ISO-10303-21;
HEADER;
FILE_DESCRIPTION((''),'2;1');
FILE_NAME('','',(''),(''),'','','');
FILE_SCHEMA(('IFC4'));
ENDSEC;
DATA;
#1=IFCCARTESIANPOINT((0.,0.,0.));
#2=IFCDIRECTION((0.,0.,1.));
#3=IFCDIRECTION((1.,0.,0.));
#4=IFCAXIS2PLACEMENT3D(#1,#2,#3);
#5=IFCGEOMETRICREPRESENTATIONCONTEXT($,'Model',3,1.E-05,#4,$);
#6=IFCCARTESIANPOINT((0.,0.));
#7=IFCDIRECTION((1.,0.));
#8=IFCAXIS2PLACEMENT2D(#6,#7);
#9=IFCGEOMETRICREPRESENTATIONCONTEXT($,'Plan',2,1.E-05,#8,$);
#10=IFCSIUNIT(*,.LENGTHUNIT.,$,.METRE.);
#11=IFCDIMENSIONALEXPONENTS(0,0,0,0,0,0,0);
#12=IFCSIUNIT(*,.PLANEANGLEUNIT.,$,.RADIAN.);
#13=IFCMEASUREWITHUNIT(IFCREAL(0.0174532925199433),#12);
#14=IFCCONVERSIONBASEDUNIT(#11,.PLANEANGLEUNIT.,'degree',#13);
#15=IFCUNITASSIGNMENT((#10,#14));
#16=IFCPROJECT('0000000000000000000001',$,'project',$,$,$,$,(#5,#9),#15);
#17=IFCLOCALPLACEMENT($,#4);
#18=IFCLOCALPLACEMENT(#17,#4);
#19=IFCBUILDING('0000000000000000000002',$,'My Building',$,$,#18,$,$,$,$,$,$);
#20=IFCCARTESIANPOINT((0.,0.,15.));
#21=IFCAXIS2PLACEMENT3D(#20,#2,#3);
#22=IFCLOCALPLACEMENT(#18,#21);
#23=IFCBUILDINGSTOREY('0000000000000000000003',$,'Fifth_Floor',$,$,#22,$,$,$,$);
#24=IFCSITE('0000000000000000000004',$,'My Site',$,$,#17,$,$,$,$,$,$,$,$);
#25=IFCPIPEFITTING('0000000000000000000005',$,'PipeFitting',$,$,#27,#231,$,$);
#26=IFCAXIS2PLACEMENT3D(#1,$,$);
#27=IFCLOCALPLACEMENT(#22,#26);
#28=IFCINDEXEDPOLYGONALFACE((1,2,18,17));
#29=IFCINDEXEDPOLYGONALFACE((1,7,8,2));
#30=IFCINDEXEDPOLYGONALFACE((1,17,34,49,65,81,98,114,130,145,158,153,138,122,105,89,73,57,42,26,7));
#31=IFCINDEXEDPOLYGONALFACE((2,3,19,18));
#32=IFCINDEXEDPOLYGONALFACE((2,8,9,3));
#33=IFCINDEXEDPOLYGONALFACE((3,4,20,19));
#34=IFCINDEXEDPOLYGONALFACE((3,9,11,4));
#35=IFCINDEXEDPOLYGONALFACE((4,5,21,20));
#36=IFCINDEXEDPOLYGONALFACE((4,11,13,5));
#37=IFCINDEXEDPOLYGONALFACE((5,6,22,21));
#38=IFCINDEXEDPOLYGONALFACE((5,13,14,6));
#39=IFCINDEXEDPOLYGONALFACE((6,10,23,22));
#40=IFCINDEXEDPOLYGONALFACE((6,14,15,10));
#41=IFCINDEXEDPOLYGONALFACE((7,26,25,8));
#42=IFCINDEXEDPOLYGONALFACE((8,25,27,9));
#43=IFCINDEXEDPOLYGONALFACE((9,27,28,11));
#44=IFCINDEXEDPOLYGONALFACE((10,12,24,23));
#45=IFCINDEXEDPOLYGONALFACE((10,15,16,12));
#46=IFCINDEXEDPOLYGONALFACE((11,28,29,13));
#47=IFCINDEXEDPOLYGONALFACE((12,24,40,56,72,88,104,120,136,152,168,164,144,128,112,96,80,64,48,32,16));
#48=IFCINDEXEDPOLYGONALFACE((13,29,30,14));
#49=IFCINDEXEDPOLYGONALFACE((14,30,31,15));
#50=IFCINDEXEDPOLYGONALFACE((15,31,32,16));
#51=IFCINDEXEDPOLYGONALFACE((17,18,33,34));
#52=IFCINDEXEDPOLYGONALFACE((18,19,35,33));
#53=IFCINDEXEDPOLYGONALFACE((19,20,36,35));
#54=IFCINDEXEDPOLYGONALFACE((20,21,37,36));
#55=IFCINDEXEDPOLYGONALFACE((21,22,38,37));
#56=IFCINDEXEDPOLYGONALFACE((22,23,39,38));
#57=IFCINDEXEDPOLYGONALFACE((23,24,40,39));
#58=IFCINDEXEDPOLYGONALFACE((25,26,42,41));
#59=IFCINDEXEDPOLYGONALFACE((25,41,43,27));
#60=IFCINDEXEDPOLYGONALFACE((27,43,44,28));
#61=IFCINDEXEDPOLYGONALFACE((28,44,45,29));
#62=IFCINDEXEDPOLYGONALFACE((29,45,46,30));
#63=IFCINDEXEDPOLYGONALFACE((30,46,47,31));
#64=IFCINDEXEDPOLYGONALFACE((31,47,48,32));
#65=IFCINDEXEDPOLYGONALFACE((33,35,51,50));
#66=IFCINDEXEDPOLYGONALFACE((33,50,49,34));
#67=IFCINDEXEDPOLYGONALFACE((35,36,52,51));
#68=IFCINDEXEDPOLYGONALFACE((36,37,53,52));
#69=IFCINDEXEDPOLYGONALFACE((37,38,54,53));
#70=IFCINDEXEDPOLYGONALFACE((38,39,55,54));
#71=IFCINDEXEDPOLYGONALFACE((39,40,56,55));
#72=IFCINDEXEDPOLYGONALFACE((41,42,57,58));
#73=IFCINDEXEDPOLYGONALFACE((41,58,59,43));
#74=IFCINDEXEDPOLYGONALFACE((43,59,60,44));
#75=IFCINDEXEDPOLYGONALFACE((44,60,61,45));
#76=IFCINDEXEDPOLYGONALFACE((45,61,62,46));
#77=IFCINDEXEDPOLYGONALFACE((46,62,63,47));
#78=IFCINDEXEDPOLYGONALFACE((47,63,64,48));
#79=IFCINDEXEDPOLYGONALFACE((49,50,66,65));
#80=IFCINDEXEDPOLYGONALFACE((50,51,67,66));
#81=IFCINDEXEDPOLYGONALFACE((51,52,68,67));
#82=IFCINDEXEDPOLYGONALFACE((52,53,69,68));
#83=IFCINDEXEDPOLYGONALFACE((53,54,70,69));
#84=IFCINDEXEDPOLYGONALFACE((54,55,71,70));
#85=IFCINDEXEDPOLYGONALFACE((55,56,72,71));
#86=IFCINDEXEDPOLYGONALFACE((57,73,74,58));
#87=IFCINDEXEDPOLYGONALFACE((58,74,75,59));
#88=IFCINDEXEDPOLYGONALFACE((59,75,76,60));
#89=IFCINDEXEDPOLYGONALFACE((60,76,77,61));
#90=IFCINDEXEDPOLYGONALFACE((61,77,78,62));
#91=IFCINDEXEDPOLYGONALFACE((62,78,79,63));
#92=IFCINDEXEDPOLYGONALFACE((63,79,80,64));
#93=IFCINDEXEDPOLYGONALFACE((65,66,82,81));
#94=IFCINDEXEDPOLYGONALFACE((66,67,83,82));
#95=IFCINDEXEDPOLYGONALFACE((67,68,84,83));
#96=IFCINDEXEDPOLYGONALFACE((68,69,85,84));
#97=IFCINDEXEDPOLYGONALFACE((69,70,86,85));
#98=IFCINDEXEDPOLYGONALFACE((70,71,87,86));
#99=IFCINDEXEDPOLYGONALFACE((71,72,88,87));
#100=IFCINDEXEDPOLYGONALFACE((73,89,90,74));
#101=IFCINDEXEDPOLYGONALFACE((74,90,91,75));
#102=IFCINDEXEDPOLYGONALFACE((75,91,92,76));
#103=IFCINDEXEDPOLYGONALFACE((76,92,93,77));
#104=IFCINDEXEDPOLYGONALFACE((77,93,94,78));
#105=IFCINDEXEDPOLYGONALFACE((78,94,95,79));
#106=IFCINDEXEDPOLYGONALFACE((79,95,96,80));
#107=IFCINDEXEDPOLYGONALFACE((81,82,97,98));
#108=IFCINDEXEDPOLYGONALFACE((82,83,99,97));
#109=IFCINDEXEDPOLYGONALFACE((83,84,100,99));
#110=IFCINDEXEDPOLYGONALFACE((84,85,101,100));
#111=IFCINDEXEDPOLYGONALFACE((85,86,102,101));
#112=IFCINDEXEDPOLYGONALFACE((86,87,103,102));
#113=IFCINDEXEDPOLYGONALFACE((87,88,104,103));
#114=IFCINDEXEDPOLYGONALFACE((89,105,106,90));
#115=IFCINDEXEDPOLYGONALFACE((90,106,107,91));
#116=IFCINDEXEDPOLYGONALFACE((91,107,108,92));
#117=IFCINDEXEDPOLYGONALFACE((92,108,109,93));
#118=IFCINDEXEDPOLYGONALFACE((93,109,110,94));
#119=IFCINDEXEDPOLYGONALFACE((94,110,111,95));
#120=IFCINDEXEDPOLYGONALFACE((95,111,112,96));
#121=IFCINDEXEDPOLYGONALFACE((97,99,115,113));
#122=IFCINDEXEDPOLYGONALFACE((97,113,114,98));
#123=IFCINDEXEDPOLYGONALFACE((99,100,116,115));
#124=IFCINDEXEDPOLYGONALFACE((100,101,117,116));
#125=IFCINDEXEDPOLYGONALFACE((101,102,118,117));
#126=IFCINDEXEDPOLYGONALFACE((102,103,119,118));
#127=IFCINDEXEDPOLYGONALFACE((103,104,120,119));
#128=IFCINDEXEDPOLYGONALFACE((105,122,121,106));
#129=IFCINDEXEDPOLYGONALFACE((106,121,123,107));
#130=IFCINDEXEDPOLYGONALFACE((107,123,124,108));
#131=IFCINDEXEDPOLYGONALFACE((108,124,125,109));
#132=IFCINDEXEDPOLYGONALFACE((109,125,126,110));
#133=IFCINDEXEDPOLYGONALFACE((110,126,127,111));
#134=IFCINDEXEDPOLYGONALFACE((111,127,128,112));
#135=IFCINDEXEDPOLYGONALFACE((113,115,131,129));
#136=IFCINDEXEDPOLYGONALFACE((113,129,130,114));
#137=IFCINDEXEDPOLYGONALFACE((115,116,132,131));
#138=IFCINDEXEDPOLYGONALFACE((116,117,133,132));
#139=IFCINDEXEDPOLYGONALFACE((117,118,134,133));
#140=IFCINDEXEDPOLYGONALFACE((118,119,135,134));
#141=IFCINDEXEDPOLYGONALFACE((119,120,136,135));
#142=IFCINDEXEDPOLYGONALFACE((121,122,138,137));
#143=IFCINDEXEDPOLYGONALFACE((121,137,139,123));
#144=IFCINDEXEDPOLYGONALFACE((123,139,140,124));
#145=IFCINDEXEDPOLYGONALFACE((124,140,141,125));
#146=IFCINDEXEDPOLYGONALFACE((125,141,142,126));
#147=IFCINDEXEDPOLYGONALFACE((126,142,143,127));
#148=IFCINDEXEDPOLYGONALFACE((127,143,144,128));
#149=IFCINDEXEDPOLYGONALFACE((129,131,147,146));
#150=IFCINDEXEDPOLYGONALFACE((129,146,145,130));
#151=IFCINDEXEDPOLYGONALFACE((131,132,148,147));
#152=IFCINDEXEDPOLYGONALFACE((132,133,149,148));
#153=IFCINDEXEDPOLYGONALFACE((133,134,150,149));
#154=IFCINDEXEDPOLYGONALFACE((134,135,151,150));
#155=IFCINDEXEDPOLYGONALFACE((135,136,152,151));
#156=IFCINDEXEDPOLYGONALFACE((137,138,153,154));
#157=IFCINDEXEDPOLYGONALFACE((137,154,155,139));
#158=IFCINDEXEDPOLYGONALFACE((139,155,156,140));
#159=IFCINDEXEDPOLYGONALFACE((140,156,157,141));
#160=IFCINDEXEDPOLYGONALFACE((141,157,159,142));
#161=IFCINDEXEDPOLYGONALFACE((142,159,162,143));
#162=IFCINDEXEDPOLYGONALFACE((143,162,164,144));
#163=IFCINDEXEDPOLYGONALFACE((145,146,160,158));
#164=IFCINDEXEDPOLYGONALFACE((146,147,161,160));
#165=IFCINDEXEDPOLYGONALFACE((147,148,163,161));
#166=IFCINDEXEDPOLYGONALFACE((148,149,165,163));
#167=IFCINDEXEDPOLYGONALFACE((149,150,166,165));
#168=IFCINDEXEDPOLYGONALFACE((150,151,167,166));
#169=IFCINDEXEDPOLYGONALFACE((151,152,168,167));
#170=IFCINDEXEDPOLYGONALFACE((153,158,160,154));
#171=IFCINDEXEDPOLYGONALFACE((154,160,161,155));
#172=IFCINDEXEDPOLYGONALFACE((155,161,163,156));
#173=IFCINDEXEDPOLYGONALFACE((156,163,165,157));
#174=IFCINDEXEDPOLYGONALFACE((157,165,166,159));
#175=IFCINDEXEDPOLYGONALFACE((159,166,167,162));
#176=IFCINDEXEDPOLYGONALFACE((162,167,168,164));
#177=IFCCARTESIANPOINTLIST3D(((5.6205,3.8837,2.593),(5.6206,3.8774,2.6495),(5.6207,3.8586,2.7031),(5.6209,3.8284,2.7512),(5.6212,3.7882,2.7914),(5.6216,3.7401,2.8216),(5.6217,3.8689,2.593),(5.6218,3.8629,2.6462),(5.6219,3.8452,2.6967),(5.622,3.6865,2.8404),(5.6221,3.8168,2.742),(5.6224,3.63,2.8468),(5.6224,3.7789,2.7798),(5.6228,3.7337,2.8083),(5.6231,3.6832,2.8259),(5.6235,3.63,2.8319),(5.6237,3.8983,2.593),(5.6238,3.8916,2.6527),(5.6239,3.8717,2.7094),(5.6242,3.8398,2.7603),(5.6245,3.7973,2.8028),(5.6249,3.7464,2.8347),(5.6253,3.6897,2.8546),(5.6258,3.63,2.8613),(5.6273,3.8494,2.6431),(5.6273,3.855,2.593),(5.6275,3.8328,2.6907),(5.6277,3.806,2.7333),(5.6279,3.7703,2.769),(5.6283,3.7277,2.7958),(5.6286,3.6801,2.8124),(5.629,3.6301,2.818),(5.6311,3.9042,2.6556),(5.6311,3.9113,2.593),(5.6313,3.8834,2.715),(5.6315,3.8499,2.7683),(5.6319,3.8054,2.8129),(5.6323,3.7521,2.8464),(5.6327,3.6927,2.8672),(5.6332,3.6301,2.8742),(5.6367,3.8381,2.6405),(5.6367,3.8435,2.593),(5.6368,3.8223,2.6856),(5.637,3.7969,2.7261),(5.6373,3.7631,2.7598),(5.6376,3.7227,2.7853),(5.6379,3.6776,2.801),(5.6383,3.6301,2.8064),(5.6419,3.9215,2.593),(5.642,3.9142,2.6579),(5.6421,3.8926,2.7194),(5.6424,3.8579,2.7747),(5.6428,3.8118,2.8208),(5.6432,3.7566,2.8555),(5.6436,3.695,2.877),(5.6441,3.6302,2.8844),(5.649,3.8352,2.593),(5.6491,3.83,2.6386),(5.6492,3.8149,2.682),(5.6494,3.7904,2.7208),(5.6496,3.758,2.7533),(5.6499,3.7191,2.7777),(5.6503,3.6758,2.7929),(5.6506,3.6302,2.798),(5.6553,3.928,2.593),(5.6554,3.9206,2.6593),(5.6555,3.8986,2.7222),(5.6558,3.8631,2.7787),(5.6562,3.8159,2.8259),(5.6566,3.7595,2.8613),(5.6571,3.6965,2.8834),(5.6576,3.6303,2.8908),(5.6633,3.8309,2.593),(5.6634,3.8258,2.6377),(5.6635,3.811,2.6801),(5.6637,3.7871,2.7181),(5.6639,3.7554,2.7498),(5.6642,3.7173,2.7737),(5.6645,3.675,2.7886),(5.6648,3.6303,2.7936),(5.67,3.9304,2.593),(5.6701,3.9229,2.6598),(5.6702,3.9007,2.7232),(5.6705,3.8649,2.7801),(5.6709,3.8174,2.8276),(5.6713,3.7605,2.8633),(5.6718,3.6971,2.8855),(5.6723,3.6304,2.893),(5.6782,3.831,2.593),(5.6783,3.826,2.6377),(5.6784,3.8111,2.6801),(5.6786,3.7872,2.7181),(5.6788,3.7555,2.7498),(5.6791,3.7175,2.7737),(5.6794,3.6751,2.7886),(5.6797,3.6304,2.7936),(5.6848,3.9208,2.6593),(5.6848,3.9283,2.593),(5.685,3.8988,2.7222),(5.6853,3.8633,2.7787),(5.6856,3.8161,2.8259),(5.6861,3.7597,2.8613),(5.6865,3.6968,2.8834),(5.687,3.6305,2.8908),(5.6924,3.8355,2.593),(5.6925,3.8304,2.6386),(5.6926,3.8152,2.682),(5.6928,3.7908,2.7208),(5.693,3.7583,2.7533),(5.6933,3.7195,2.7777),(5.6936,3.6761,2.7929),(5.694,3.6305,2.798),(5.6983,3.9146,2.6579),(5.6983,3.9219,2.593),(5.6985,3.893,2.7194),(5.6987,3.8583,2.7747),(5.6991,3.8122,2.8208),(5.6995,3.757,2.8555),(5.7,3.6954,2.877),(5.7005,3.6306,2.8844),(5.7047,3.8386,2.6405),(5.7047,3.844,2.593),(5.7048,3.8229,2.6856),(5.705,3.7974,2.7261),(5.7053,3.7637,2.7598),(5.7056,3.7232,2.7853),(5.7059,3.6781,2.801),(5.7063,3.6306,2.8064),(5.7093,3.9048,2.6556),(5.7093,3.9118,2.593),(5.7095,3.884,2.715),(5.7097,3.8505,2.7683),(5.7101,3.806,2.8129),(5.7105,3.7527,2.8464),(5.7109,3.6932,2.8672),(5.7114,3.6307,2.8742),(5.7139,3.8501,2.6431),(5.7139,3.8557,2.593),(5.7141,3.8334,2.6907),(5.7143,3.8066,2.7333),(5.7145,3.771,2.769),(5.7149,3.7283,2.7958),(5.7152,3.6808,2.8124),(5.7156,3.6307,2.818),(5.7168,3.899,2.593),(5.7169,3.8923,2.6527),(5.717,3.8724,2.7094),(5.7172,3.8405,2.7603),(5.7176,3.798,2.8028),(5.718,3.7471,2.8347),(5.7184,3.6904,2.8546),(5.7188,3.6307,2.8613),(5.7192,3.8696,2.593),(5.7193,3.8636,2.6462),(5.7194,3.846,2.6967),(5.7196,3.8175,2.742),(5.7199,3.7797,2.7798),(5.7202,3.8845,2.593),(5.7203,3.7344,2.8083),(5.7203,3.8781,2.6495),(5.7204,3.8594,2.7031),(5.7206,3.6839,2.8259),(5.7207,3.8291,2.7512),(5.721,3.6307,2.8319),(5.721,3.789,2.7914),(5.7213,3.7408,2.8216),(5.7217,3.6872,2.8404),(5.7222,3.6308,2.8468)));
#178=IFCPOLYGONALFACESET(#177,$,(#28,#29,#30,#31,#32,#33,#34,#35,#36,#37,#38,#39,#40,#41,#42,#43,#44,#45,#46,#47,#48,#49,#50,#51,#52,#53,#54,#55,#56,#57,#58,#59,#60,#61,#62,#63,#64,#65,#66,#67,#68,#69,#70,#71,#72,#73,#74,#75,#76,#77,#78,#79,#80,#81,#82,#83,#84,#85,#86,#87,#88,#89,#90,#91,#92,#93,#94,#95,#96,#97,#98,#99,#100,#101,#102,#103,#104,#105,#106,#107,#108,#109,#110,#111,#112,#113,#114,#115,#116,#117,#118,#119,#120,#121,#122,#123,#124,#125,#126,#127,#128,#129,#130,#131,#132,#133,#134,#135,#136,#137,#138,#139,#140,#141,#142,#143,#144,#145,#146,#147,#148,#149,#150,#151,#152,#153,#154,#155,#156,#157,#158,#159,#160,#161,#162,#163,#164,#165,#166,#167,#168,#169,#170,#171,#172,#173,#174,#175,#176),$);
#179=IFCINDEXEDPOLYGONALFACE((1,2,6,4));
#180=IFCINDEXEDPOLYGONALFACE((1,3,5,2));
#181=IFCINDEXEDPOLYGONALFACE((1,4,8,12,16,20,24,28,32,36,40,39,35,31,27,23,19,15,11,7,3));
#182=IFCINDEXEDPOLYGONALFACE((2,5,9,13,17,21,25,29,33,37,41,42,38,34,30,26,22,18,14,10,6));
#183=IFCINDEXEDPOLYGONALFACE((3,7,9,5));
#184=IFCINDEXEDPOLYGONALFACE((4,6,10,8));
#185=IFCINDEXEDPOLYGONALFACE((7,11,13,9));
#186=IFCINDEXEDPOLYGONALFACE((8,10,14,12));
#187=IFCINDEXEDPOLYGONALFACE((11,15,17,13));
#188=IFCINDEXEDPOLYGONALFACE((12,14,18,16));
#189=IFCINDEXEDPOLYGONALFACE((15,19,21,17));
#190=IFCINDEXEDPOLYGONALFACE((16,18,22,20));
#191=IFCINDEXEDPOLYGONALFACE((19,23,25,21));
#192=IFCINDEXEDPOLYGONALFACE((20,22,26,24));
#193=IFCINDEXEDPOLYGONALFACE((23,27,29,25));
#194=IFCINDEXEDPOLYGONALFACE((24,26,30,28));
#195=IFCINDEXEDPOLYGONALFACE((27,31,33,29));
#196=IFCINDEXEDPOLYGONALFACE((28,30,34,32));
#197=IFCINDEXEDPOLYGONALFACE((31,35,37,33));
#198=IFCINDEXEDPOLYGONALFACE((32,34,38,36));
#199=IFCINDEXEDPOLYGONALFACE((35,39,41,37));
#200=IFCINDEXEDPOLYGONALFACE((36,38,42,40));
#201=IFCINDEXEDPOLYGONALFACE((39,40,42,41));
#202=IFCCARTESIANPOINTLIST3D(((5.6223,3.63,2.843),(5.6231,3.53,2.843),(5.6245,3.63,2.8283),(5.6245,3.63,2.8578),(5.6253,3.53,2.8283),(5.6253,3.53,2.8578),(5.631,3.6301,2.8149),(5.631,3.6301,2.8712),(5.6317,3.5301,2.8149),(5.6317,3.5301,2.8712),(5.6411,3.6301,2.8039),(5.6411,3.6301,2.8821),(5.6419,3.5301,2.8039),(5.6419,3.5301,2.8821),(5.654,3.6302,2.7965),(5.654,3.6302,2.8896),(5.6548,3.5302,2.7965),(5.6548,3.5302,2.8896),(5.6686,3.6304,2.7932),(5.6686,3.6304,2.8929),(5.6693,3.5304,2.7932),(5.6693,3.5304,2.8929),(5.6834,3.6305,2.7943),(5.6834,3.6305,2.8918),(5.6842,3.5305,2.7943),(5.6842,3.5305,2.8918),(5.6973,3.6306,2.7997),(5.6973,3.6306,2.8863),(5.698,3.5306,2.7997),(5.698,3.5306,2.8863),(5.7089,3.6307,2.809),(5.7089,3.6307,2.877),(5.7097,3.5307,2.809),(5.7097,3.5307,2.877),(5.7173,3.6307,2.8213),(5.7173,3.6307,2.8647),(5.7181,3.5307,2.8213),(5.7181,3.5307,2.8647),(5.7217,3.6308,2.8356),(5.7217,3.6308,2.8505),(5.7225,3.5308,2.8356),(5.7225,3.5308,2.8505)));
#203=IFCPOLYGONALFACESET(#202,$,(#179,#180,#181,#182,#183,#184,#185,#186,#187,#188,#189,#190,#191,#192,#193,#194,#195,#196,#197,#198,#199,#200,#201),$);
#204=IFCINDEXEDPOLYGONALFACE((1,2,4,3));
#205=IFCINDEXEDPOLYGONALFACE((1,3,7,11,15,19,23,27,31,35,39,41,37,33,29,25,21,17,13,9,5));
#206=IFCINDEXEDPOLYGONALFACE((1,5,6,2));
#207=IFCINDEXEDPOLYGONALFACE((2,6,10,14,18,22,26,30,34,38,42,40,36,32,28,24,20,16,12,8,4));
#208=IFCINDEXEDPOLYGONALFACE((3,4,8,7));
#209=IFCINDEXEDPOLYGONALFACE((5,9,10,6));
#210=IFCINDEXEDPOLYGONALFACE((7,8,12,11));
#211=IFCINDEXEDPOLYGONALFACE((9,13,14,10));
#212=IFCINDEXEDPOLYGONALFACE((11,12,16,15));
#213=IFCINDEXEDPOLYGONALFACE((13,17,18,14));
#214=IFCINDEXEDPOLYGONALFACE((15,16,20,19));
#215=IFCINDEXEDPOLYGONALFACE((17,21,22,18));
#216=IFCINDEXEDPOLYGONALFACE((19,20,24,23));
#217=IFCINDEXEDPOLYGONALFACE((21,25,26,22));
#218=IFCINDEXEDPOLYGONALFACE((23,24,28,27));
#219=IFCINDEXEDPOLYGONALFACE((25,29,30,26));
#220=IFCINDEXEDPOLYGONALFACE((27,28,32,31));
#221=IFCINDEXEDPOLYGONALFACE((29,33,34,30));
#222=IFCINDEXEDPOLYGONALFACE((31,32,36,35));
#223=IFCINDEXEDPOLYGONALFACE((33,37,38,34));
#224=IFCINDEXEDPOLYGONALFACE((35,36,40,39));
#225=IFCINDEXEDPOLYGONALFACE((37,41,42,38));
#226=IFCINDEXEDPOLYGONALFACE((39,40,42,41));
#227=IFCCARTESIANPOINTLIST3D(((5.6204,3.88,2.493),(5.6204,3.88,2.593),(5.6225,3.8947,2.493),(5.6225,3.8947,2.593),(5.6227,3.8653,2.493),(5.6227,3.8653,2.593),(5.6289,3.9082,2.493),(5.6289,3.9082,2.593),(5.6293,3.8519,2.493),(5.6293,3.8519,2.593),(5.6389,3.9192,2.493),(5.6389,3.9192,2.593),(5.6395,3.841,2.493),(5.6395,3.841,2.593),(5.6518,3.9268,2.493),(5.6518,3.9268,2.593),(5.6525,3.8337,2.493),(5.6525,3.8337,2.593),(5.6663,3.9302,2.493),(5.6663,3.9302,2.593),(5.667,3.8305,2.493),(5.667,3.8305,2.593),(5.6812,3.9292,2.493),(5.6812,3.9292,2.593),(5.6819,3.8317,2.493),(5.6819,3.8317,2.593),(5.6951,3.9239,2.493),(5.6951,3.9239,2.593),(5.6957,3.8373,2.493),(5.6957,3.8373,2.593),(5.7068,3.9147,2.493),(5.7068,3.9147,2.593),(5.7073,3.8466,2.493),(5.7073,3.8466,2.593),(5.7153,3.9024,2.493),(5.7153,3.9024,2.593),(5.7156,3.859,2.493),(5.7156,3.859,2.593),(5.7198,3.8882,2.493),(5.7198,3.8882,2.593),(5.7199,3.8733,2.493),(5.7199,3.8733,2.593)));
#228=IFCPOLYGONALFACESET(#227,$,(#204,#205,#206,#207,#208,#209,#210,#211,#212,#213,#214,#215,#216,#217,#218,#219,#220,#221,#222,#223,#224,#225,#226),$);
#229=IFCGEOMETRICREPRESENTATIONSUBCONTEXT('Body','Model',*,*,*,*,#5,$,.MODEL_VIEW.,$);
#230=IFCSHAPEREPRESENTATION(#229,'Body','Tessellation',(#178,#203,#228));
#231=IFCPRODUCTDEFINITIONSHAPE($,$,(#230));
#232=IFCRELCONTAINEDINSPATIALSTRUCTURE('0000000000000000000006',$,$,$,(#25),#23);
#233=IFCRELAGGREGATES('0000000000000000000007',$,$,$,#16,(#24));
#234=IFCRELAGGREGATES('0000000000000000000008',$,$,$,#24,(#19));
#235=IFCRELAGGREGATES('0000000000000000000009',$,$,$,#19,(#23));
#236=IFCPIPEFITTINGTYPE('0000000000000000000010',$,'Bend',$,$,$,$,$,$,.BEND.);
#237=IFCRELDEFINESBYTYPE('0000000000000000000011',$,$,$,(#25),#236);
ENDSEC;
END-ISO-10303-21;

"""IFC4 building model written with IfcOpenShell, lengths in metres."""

from ifc_helpers import new_model, entity, si_unit, converted_unit, frame, origin_with_axes, origin_2d_with_axis, place, context, subcontext, project, spatial, circle, extrude, source, transform, mapped, type_object, type_shapes, element, save


model = new_model("IFC4")

# Units and contexts
model_context = context("Model", 3, precision=1e-05, world=origin_with_axes())
plan_context = context("Plan", 2, precision=1e-05, world=origin_2d_with_axis())
body_context = subcontext(model_context, "Body", "Model", "MODEL_VIEW")
ifc_project = project(units=[si_unit("LENGTHUNIT", "METRE"), converted_unit("PLANEANGLEUNIT", "degree", entity("IfcReal", 0.0174532925199433), si_unit("PLANEANGLEUNIT", "RADIAN"), dimensions=[0, 0, 0, 0, 0, 0, 0])], contexts=[model_context, plan_context])

# Site, building, storey
site_placement = place(None, origin_with_axes())
site = spatial("IfcSite", under=ifc_project, at=site_placement, Name="My Site")
building_placement = place(site_placement, origin_with_axes())
building = spatial("IfcBuilding", under=site, at=building_placement, Name="My Building")
storey_placement = place(building_placement, frame((0.0, 0.0, 15.0), z_axis=(0.0, 0.0, 1.0), x_axis=(1.0, 0.0, 0.0)))
storey = spatial("IfcBuildingStorey", under=building, at=storey_placement, Name="Fifth_Floor")

# Pipe fitting
pipe_fitting_type = type_object("IfcPipeFittingType", Name="Bend", PredefinedType="BEND")
shared_shape = source(origin_with_axes(), body_context, "Body", "SolidModel", [
    entity("IfcSweptDiskSolid", entity("IfcIndexedPolyCurve", entity("IfcCartesianPointList3D", [[0.0, 0.0, -0.1], [0.0, 0.0732, -0.2768], [0.0, 0.25, -0.35]]), [entity("IfcArcIndex", [1, 2, 3])]), 0.05),
    extrude(circle(Radius=0.05), origin_with_axes(), (0.0, 0.0, -1.0), 0.1),
    extrude(circle(Radius=0.05), frame((0.0, 0.25, -0.35), z_axis=(0.0, 1.0, 0.0), x_axis=(1.0, 0.0, 0.0)), (0.0, 0.0, 1.0), 0.1),
])
type_shapes(pipe_fitting_type, [shared_shape])
for number, where, z_axis, x_axis, name in (
    (1, (5.673, 3.5304, 2.843), (0.007564, -0.999971, 0.0), (-0.999971, -0.007564, 0.0), "PipeFitting"),
):
    element("IfcPipeFitting", number, at=place(storey_placement, frame(where, z_axis=z_axis, x_axis=x_axis)), inside=storey, type_object=pipe_fitting_type, Name=name, context=body_context, shape_type="MappedRepresentation", body=[
        mapped(shared_shape, transform((0.0, 0.0, 0.0), x_axis=(1.0, 0.0, 0.0), y_axis=(0.0, 1.0, 0.0), z_axis=(0.0, 0.0, 1.0), scale=1.0)),
    ])

save(model, "model.ifc")
